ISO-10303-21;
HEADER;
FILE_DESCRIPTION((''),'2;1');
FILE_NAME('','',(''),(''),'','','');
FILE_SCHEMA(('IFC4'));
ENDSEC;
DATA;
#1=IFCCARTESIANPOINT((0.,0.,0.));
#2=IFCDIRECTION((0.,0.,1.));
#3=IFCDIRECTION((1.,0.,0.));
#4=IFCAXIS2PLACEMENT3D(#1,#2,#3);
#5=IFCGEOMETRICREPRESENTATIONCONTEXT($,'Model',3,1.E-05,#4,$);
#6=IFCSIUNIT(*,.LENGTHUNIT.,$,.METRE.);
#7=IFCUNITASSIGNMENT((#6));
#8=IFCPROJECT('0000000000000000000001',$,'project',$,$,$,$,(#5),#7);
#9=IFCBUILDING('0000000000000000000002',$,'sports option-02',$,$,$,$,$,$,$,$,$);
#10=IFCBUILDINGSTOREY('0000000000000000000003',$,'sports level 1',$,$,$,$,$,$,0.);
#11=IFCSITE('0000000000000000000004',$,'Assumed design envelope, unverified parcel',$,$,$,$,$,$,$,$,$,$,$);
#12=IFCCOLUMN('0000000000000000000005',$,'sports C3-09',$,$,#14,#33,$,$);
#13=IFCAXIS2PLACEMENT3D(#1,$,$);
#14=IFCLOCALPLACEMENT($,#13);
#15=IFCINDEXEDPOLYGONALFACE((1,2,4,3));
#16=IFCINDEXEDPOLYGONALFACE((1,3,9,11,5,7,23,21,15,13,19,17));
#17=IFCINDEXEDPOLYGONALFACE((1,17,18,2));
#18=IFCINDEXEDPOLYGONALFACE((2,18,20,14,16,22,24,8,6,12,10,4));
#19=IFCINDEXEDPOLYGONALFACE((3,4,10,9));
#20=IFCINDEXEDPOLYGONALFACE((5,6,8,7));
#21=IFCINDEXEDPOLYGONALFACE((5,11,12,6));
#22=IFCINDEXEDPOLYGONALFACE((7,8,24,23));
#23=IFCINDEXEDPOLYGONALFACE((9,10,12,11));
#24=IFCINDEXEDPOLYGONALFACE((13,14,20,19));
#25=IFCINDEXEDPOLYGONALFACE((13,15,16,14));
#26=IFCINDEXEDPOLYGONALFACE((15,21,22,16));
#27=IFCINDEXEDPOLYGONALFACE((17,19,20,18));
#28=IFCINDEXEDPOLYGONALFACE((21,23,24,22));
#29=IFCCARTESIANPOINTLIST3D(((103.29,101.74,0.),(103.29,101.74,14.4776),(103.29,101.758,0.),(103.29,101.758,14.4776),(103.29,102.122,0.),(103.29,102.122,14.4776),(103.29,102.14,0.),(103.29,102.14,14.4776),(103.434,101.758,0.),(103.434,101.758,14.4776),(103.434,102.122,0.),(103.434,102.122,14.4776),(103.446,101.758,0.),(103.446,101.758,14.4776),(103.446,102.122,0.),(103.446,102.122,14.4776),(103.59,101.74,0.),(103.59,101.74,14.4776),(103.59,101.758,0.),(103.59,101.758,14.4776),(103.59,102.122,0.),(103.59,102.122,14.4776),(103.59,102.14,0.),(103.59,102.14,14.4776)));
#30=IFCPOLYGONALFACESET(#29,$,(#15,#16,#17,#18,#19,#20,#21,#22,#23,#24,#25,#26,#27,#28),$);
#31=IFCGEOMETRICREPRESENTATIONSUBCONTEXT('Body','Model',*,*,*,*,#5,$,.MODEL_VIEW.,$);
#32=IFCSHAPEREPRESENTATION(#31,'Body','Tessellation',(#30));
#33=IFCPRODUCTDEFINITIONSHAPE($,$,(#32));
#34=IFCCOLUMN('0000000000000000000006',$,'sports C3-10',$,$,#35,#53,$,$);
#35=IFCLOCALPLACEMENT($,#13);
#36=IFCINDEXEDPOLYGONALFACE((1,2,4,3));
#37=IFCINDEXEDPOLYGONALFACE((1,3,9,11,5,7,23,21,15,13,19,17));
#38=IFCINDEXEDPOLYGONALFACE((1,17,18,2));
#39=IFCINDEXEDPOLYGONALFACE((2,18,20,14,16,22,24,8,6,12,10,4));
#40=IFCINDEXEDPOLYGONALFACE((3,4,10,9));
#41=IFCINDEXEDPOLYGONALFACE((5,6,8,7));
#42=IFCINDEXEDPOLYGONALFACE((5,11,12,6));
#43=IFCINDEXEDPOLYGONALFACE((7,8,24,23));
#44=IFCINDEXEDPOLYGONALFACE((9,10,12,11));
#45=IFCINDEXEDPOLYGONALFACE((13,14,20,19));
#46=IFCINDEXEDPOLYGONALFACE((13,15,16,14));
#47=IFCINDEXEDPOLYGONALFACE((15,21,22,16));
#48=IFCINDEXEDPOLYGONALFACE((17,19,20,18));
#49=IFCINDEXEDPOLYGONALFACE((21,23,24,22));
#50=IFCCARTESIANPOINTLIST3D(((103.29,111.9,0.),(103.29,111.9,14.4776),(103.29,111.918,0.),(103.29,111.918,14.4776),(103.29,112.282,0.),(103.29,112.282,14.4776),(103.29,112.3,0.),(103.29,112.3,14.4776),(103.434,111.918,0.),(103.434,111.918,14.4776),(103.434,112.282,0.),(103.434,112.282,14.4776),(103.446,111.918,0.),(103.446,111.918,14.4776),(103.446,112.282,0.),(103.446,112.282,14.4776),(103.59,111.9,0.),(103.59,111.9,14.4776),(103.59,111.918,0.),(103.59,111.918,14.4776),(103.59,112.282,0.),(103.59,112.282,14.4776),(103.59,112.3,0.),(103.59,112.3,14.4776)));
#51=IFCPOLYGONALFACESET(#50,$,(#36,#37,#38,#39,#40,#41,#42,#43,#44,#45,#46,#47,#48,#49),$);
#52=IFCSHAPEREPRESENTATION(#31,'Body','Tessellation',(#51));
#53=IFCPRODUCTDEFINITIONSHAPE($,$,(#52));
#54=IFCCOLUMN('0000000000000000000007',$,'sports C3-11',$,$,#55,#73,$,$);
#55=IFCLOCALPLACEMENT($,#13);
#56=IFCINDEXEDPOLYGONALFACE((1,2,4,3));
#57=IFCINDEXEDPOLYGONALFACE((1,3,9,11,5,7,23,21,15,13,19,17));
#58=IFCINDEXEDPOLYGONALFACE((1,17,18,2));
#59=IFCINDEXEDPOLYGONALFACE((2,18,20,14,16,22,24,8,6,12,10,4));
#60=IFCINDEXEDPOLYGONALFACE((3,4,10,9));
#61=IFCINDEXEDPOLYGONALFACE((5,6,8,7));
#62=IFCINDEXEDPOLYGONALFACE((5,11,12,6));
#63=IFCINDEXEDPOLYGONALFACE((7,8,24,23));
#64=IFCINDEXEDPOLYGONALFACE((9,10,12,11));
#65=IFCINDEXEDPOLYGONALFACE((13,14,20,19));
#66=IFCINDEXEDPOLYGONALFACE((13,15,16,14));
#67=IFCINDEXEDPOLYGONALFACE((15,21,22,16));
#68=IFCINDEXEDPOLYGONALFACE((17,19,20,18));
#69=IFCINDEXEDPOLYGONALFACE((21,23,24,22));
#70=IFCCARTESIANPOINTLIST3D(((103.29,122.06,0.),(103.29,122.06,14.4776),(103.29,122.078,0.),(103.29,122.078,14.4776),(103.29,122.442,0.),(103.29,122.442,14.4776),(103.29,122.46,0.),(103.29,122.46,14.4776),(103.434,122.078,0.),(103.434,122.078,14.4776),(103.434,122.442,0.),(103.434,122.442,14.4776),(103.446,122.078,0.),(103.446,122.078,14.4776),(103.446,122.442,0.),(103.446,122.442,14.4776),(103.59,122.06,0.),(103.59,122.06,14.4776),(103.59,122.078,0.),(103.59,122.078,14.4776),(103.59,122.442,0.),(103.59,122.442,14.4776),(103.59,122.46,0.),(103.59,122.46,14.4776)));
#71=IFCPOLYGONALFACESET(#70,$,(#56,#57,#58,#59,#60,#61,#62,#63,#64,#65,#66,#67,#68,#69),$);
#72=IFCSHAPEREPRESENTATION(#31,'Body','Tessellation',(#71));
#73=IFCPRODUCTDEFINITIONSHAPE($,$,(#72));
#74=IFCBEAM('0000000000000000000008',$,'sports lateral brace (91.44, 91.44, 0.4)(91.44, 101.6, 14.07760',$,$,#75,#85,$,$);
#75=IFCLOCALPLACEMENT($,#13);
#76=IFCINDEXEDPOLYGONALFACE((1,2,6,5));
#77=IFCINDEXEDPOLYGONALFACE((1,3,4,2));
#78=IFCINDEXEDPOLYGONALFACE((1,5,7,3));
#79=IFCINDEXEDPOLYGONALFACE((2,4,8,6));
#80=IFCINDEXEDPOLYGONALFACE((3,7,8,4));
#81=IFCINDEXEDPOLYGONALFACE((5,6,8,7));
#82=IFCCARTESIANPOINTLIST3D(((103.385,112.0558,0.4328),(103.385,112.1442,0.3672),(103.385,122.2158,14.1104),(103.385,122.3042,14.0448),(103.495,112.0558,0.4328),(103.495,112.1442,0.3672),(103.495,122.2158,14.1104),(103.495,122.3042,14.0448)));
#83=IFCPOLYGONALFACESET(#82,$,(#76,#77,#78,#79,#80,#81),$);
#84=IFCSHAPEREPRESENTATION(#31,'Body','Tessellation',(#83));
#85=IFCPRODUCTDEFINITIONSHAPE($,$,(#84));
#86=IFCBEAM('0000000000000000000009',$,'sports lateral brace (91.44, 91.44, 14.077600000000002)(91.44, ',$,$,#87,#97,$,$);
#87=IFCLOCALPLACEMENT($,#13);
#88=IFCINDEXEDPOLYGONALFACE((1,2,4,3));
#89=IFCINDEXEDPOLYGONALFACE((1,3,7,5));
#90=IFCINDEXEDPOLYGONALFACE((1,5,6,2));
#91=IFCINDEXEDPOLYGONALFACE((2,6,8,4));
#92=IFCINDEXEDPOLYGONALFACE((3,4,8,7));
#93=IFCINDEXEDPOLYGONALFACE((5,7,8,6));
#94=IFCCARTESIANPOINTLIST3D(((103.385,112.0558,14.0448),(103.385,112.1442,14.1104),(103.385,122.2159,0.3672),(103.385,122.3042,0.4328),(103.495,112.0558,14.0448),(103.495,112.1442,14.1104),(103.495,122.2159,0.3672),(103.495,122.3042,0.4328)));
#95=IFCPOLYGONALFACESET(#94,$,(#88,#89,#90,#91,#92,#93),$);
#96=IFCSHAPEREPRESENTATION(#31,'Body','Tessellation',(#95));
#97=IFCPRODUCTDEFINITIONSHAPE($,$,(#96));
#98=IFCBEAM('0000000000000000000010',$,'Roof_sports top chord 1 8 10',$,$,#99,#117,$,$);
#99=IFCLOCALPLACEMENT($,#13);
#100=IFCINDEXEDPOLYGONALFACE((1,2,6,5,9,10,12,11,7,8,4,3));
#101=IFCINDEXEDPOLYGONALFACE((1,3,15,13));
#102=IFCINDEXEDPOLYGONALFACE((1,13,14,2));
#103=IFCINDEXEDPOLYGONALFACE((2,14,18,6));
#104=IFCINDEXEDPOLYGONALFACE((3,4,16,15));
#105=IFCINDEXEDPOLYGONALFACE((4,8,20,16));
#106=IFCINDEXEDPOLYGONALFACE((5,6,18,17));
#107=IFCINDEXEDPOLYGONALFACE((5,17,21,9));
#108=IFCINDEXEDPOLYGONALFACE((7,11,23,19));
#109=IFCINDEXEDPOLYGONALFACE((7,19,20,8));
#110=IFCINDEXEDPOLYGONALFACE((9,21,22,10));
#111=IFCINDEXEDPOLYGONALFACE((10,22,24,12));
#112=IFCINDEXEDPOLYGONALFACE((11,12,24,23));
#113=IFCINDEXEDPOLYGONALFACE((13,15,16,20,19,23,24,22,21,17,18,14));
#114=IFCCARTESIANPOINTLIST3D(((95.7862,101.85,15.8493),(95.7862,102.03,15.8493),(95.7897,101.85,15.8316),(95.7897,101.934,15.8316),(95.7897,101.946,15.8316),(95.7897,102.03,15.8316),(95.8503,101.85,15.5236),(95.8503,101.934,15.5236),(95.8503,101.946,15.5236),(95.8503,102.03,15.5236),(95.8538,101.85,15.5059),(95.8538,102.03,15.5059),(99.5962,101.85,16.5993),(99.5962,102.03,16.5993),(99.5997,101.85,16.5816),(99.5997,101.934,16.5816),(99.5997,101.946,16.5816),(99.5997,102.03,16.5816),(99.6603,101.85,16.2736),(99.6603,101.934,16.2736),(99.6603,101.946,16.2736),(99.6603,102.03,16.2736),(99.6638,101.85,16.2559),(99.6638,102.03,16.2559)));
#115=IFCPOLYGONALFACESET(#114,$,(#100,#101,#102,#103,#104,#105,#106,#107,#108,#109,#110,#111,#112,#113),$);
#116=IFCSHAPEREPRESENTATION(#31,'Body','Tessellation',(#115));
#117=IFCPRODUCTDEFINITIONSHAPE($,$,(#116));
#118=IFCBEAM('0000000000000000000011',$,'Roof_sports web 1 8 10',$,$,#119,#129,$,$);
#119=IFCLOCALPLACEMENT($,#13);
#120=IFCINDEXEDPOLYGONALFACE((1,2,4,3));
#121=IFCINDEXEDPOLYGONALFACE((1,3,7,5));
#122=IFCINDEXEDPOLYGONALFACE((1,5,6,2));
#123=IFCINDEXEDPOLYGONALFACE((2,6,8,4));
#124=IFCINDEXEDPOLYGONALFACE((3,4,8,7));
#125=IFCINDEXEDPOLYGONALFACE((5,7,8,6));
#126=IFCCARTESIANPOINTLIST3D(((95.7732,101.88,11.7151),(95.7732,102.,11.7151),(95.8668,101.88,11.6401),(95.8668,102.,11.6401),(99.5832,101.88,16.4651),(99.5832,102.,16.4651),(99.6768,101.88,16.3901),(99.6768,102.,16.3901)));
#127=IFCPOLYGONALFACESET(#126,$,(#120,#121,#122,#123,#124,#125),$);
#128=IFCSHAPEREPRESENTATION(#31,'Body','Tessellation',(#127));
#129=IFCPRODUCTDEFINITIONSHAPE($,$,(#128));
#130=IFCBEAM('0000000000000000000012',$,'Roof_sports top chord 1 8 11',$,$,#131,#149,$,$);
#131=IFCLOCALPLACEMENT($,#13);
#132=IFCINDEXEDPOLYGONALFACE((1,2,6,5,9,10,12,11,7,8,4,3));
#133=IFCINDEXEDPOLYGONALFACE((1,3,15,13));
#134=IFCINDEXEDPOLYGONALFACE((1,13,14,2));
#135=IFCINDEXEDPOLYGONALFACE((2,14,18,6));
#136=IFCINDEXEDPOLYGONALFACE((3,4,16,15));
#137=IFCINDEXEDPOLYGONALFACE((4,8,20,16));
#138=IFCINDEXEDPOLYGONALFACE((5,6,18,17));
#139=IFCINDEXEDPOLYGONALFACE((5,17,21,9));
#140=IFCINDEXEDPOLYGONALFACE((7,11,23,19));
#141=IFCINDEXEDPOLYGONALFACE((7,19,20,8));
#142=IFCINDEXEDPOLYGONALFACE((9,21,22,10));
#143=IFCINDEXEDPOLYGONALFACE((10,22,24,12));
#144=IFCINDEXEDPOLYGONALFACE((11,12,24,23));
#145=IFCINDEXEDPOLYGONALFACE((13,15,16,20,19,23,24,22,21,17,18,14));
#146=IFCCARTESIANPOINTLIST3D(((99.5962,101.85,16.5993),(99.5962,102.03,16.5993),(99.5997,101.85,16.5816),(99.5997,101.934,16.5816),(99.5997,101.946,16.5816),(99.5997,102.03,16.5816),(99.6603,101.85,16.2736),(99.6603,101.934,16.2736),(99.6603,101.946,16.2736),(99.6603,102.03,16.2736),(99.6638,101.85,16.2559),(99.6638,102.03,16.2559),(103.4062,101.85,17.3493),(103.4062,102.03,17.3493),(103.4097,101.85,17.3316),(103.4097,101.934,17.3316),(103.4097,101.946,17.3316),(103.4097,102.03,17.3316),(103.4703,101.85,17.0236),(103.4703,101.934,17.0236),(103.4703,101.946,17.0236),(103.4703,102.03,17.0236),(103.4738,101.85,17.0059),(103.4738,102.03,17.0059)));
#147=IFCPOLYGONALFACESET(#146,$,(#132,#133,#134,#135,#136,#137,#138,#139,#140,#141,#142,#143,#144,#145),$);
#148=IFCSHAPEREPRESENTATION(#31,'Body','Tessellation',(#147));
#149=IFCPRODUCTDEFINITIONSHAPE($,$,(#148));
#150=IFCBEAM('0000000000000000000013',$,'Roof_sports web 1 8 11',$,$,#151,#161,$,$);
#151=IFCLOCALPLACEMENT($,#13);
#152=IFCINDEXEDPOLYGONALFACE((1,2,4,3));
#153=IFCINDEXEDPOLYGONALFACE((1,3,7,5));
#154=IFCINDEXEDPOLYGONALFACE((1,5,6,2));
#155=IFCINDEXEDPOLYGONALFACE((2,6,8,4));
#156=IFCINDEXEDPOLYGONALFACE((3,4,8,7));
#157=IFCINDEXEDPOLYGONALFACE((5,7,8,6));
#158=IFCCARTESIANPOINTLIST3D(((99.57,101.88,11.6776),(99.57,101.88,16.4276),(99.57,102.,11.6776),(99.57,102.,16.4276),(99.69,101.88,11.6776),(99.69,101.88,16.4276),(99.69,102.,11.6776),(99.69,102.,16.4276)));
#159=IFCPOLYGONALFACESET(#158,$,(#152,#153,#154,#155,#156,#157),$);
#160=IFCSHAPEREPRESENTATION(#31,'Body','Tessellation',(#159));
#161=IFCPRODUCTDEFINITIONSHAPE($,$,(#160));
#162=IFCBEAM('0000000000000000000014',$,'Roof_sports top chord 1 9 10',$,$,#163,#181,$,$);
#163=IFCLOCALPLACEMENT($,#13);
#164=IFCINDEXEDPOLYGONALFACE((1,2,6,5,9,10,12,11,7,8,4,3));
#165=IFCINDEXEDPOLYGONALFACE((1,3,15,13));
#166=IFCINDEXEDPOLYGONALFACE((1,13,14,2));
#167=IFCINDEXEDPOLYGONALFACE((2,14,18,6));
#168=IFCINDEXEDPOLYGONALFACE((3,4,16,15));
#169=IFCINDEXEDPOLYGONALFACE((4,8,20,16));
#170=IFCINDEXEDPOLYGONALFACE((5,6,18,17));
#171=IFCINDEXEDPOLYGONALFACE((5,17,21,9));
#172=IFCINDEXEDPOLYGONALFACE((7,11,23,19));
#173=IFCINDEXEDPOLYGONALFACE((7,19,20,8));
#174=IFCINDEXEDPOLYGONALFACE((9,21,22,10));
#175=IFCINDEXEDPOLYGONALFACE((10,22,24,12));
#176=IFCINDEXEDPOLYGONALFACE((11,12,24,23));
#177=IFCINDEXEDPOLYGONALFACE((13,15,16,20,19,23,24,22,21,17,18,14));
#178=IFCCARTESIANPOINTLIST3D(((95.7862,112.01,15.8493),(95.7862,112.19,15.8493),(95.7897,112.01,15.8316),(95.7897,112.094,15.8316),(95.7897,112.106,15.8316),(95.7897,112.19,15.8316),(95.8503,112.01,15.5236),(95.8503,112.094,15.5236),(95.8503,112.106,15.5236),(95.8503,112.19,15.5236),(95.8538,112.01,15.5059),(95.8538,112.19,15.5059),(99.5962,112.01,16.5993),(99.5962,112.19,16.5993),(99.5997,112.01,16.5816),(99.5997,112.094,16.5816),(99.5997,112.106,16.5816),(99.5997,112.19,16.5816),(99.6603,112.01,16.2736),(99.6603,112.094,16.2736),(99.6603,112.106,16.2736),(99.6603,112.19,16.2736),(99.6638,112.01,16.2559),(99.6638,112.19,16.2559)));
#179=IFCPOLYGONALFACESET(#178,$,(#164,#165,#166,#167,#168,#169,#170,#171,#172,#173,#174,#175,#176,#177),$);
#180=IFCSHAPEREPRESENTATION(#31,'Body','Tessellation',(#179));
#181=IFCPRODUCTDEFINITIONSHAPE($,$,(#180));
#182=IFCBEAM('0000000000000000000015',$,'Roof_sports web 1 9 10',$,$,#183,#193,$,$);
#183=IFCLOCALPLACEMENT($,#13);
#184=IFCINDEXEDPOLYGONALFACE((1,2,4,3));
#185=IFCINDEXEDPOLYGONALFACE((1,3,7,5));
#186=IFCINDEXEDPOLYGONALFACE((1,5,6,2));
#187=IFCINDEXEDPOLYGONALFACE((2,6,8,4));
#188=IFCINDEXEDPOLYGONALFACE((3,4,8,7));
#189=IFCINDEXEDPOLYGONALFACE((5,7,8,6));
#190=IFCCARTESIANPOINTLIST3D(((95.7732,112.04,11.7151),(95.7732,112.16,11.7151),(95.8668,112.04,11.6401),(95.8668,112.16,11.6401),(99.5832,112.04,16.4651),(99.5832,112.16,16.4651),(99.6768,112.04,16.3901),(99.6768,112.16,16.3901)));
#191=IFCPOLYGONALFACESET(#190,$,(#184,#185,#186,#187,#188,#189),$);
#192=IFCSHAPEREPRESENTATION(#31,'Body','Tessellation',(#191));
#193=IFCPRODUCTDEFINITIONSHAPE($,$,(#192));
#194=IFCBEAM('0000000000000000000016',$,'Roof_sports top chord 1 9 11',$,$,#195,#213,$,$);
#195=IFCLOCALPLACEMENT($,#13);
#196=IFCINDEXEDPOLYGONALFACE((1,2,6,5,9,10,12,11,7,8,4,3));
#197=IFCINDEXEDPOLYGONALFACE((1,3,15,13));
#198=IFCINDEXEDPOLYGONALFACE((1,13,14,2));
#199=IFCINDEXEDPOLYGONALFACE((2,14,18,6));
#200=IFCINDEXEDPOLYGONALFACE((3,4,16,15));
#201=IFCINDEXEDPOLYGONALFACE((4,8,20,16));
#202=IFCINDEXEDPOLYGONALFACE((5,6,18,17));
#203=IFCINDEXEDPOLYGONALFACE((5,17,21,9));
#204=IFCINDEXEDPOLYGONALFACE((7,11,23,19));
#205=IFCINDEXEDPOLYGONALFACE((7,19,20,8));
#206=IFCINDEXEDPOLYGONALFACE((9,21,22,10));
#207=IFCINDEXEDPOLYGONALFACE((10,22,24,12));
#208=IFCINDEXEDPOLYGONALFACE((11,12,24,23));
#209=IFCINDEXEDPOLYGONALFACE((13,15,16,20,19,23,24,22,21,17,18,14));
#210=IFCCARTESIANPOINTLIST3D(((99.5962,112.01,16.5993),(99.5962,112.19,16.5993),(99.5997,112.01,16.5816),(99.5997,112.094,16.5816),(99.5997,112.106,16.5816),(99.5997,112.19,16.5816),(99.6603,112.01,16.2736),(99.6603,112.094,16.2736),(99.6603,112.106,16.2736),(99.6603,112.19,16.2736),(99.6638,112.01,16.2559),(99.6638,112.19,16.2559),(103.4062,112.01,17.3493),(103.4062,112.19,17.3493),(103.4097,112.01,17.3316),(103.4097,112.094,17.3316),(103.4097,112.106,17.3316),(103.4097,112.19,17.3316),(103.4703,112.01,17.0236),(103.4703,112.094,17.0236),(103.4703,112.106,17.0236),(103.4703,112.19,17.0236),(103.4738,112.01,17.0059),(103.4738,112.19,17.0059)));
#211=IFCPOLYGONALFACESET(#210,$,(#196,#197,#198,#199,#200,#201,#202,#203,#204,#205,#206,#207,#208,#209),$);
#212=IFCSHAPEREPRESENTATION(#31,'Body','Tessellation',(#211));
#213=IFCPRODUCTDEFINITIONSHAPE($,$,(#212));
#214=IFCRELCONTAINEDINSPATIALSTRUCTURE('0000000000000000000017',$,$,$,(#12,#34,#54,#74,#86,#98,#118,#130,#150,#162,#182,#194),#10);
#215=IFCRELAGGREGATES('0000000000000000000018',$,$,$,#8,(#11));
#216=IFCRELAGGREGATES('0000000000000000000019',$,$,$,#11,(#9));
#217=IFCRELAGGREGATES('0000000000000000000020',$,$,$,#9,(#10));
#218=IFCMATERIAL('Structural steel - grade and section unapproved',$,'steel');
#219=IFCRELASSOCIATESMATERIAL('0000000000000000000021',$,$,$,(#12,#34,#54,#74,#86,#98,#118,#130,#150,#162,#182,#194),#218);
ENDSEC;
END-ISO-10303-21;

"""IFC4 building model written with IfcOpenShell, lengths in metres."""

from ifc_helpers import new_model, si_unit, frame, origin_with_axes, place, context, subcontext, project, spatial, rectangle, i_section, extrude, material, element, save


model = new_model("IFC4")

# Units and contexts
model_context = context("Model", 3, precision=1e-05, world=origin_with_axes())
body_context = subcontext(model_context, "Body", "Model", "MODEL_VIEW")
ifc_project = project(units=[si_unit("LENGTHUNIT", "METRE")], contexts=[model_context])

# Site, building, storey
site = spatial("IfcSite", under=ifc_project, Name="Assumed design envelope, unverified parcel")
building = spatial("IfcBuilding", under=site, Name="sports option-02")
storey = spatial("IfcBuildingStorey", under=building, Name="sports level 1", Elevation=0.0)

# Columns
ifc_material_1 = material(Name="Structural steel - grade and section unapproved", Category="steel")
for number, where, z_axis, x_axis, name in (
    (1, (103.44, 101.94, 0.0), (0.0, 0.0, 1.0), (-1.0, 0.0, 0.0), "sports C3-09"),
    (2, (103.44, 112.1, 0.0), (0.0, 0.0, 1.0), (-1.0, 0.0, 0.0), "sports C3-10"),
    (3, (103.44, 122.26, 0.0), (0.0, 0.0, 1.0), (-1.0, 0.0, 0.0), "sports C3-11"),
):
    element("IfcColumn", number, at=place(None, frame(where, z_axis=z_axis, x_axis=x_axis)), inside=storey, material=ifc_material_1, Name=name, context=body_context, shape_type="SweptSolid", body=[
        extrude(i_section(OverallWidth=0.3, OverallDepth=0.4, WebThickness=0.012, FlangeThickness=0.018, FilletRadius=0.0), origin_with_axes(), (0.0, 0.0, 1.0), 14.4776),
    ])

# Beams
for number, where, z_axis, x_axis, name in (
    (4, (103.44, 112.1, 0.4), (0.0, 0.596305, 0.802758), (-1.0, 0.0, 0.0), "sports lateral brace (91.44, 91.44, 0.4)(91.44, 101.6, 14.07760"),
    (5, (103.44, 112.1, 14.0776), (0.0, 0.596305, -0.802758), (-1.0, 0.0, 0.0), "sports lateral brace (91.44, 91.44, 14.077600000000002)(91.44, "),
):
    element("IfcBeam", number, at=place(None, frame(where, z_axis=z_axis, x_axis=x_axis)), inside=storey, material=ifc_material_1, Name=name, context=body_context, shape_type="SweptSolid", body=[
        extrude(rectangle(XDim=0.11, YDim=0.11), origin_with_axes(), (0.0, 0.0, 1.0), 17.0383),
    ])
beam_1_placement = place(None, frame((95.82, 101.94, 15.6776), z_axis=(0.98117, 0.0, 0.193144), x_axis=(0.0, 1.0, 0.0)))
element("IfcBeam", 6, at=beam_1_placement, inside=storey, material=ifc_material_1, Name="Roof_sports top chord 1 8 10", context=body_context, shape_type="SweptSolid", body=[
    extrude(i_section(OverallWidth=0.18, OverallDepth=0.35, WebThickness=0.012, FlangeThickness=0.018, FilletRadius=0.0), origin_with_axes(), (0.0, 0.0, 1.0), 3.8831),
])
beam_2_placement = place(None, frame((95.82, 101.94, 11.6776), z_axis=(0.625696, 0.0, 0.780067), x_axis=(0.0, 1.0, 0.0)))
element("IfcBeam", 7, at=beam_2_placement, inside=storey, material=ifc_material_1, Name="Roof_sports web 1 8 10", context=body_context, shape_type="SweptSolid", body=[
    extrude(rectangle(XDim=0.12, YDim=0.12), origin_with_axes(), (0.0, 0.0, 1.0), 6.0892),
])
beam_3_placement = place(None, frame((99.63, 101.94, 16.4276), z_axis=(0.981171, 0.0, 0.193143), x_axis=(0.0, 1.0, 0.0)))
element("IfcBeam", 8, at=beam_3_placement, inside=storey, material=ifc_material_1, Name="Roof_sports top chord 1 8 11", context=body_context, shape_type="SweptSolid", body=[
    extrude(i_section(OverallWidth=0.18, OverallDepth=0.35, WebThickness=0.012, FlangeThickness=0.018, FilletRadius=0.0), origin_with_axes(), (0.0, 0.0, 1.0), 3.8831),
])
beam_4_placement = place(None, frame((99.63, 101.94, 11.6776), z_axis=(0.0, 0.0, 1.0), x_axis=(-1.0, 0.0, 0.0)))
element("IfcBeam", 9, at=beam_4_placement, inside=storey, material=ifc_material_1, Name="Roof_sports web 1 8 11", context=body_context, shape_type="SweptSolid", body=[
    extrude(rectangle(XDim=0.12, YDim=0.12), origin_with_axes(), (0.0, 0.0, 1.0), 4.75),
])
beam_5_placement = place(None, frame((95.82, 112.1, 15.6776), z_axis=(0.98117, 0.0, 0.193144), x_axis=(0.0, 1.0, 0.0)))
element("IfcBeam", 10, at=beam_5_placement, inside=storey, material=ifc_material_1, Name="Roof_sports top chord 1 9 10", context=body_context, shape_type="SweptSolid", body=[
    extrude(i_section(OverallWidth=0.18, OverallDepth=0.35, WebThickness=0.012, FlangeThickness=0.018, FilletRadius=0.0), origin_with_axes(), (0.0, 0.0, 1.0), 3.8831),
])
beam_6_placement = place(None, frame((95.82, 112.1, 11.6776), z_axis=(0.625696, 0.0, 0.780067), x_axis=(0.0, 1.0, 0.0)))
element("IfcBeam", 11, at=beam_6_placement, inside=storey, material=ifc_material_1, Name="Roof_sports web 1 9 10", context=body_context, shape_type="SweptSolid", body=[
    extrude(rectangle(XDim=0.12, YDim=0.12), origin_with_axes(), (0.0, 0.0, 1.0), 6.0892),
])
beam_7_placement = place(None, frame((99.63, 112.1, 16.4276), z_axis=(0.981171, 0.0, 0.193143), x_axis=(0.0, 1.0, 0.0)))
element("IfcBeam", 12, at=beam_7_placement, inside=storey, material=ifc_material_1, Name="Roof_sports top chord 1 9 11", context=body_context, shape_type="SweptSolid", body=[
    extrude(i_section(OverallWidth=0.18, OverallDepth=0.35, WebThickness=0.012, FlangeThickness=0.018, FilletRadius=0.0), origin_with_axes(), (0.0, 0.0, 1.0), 3.8831),
])

save(model, "model.ifc")
